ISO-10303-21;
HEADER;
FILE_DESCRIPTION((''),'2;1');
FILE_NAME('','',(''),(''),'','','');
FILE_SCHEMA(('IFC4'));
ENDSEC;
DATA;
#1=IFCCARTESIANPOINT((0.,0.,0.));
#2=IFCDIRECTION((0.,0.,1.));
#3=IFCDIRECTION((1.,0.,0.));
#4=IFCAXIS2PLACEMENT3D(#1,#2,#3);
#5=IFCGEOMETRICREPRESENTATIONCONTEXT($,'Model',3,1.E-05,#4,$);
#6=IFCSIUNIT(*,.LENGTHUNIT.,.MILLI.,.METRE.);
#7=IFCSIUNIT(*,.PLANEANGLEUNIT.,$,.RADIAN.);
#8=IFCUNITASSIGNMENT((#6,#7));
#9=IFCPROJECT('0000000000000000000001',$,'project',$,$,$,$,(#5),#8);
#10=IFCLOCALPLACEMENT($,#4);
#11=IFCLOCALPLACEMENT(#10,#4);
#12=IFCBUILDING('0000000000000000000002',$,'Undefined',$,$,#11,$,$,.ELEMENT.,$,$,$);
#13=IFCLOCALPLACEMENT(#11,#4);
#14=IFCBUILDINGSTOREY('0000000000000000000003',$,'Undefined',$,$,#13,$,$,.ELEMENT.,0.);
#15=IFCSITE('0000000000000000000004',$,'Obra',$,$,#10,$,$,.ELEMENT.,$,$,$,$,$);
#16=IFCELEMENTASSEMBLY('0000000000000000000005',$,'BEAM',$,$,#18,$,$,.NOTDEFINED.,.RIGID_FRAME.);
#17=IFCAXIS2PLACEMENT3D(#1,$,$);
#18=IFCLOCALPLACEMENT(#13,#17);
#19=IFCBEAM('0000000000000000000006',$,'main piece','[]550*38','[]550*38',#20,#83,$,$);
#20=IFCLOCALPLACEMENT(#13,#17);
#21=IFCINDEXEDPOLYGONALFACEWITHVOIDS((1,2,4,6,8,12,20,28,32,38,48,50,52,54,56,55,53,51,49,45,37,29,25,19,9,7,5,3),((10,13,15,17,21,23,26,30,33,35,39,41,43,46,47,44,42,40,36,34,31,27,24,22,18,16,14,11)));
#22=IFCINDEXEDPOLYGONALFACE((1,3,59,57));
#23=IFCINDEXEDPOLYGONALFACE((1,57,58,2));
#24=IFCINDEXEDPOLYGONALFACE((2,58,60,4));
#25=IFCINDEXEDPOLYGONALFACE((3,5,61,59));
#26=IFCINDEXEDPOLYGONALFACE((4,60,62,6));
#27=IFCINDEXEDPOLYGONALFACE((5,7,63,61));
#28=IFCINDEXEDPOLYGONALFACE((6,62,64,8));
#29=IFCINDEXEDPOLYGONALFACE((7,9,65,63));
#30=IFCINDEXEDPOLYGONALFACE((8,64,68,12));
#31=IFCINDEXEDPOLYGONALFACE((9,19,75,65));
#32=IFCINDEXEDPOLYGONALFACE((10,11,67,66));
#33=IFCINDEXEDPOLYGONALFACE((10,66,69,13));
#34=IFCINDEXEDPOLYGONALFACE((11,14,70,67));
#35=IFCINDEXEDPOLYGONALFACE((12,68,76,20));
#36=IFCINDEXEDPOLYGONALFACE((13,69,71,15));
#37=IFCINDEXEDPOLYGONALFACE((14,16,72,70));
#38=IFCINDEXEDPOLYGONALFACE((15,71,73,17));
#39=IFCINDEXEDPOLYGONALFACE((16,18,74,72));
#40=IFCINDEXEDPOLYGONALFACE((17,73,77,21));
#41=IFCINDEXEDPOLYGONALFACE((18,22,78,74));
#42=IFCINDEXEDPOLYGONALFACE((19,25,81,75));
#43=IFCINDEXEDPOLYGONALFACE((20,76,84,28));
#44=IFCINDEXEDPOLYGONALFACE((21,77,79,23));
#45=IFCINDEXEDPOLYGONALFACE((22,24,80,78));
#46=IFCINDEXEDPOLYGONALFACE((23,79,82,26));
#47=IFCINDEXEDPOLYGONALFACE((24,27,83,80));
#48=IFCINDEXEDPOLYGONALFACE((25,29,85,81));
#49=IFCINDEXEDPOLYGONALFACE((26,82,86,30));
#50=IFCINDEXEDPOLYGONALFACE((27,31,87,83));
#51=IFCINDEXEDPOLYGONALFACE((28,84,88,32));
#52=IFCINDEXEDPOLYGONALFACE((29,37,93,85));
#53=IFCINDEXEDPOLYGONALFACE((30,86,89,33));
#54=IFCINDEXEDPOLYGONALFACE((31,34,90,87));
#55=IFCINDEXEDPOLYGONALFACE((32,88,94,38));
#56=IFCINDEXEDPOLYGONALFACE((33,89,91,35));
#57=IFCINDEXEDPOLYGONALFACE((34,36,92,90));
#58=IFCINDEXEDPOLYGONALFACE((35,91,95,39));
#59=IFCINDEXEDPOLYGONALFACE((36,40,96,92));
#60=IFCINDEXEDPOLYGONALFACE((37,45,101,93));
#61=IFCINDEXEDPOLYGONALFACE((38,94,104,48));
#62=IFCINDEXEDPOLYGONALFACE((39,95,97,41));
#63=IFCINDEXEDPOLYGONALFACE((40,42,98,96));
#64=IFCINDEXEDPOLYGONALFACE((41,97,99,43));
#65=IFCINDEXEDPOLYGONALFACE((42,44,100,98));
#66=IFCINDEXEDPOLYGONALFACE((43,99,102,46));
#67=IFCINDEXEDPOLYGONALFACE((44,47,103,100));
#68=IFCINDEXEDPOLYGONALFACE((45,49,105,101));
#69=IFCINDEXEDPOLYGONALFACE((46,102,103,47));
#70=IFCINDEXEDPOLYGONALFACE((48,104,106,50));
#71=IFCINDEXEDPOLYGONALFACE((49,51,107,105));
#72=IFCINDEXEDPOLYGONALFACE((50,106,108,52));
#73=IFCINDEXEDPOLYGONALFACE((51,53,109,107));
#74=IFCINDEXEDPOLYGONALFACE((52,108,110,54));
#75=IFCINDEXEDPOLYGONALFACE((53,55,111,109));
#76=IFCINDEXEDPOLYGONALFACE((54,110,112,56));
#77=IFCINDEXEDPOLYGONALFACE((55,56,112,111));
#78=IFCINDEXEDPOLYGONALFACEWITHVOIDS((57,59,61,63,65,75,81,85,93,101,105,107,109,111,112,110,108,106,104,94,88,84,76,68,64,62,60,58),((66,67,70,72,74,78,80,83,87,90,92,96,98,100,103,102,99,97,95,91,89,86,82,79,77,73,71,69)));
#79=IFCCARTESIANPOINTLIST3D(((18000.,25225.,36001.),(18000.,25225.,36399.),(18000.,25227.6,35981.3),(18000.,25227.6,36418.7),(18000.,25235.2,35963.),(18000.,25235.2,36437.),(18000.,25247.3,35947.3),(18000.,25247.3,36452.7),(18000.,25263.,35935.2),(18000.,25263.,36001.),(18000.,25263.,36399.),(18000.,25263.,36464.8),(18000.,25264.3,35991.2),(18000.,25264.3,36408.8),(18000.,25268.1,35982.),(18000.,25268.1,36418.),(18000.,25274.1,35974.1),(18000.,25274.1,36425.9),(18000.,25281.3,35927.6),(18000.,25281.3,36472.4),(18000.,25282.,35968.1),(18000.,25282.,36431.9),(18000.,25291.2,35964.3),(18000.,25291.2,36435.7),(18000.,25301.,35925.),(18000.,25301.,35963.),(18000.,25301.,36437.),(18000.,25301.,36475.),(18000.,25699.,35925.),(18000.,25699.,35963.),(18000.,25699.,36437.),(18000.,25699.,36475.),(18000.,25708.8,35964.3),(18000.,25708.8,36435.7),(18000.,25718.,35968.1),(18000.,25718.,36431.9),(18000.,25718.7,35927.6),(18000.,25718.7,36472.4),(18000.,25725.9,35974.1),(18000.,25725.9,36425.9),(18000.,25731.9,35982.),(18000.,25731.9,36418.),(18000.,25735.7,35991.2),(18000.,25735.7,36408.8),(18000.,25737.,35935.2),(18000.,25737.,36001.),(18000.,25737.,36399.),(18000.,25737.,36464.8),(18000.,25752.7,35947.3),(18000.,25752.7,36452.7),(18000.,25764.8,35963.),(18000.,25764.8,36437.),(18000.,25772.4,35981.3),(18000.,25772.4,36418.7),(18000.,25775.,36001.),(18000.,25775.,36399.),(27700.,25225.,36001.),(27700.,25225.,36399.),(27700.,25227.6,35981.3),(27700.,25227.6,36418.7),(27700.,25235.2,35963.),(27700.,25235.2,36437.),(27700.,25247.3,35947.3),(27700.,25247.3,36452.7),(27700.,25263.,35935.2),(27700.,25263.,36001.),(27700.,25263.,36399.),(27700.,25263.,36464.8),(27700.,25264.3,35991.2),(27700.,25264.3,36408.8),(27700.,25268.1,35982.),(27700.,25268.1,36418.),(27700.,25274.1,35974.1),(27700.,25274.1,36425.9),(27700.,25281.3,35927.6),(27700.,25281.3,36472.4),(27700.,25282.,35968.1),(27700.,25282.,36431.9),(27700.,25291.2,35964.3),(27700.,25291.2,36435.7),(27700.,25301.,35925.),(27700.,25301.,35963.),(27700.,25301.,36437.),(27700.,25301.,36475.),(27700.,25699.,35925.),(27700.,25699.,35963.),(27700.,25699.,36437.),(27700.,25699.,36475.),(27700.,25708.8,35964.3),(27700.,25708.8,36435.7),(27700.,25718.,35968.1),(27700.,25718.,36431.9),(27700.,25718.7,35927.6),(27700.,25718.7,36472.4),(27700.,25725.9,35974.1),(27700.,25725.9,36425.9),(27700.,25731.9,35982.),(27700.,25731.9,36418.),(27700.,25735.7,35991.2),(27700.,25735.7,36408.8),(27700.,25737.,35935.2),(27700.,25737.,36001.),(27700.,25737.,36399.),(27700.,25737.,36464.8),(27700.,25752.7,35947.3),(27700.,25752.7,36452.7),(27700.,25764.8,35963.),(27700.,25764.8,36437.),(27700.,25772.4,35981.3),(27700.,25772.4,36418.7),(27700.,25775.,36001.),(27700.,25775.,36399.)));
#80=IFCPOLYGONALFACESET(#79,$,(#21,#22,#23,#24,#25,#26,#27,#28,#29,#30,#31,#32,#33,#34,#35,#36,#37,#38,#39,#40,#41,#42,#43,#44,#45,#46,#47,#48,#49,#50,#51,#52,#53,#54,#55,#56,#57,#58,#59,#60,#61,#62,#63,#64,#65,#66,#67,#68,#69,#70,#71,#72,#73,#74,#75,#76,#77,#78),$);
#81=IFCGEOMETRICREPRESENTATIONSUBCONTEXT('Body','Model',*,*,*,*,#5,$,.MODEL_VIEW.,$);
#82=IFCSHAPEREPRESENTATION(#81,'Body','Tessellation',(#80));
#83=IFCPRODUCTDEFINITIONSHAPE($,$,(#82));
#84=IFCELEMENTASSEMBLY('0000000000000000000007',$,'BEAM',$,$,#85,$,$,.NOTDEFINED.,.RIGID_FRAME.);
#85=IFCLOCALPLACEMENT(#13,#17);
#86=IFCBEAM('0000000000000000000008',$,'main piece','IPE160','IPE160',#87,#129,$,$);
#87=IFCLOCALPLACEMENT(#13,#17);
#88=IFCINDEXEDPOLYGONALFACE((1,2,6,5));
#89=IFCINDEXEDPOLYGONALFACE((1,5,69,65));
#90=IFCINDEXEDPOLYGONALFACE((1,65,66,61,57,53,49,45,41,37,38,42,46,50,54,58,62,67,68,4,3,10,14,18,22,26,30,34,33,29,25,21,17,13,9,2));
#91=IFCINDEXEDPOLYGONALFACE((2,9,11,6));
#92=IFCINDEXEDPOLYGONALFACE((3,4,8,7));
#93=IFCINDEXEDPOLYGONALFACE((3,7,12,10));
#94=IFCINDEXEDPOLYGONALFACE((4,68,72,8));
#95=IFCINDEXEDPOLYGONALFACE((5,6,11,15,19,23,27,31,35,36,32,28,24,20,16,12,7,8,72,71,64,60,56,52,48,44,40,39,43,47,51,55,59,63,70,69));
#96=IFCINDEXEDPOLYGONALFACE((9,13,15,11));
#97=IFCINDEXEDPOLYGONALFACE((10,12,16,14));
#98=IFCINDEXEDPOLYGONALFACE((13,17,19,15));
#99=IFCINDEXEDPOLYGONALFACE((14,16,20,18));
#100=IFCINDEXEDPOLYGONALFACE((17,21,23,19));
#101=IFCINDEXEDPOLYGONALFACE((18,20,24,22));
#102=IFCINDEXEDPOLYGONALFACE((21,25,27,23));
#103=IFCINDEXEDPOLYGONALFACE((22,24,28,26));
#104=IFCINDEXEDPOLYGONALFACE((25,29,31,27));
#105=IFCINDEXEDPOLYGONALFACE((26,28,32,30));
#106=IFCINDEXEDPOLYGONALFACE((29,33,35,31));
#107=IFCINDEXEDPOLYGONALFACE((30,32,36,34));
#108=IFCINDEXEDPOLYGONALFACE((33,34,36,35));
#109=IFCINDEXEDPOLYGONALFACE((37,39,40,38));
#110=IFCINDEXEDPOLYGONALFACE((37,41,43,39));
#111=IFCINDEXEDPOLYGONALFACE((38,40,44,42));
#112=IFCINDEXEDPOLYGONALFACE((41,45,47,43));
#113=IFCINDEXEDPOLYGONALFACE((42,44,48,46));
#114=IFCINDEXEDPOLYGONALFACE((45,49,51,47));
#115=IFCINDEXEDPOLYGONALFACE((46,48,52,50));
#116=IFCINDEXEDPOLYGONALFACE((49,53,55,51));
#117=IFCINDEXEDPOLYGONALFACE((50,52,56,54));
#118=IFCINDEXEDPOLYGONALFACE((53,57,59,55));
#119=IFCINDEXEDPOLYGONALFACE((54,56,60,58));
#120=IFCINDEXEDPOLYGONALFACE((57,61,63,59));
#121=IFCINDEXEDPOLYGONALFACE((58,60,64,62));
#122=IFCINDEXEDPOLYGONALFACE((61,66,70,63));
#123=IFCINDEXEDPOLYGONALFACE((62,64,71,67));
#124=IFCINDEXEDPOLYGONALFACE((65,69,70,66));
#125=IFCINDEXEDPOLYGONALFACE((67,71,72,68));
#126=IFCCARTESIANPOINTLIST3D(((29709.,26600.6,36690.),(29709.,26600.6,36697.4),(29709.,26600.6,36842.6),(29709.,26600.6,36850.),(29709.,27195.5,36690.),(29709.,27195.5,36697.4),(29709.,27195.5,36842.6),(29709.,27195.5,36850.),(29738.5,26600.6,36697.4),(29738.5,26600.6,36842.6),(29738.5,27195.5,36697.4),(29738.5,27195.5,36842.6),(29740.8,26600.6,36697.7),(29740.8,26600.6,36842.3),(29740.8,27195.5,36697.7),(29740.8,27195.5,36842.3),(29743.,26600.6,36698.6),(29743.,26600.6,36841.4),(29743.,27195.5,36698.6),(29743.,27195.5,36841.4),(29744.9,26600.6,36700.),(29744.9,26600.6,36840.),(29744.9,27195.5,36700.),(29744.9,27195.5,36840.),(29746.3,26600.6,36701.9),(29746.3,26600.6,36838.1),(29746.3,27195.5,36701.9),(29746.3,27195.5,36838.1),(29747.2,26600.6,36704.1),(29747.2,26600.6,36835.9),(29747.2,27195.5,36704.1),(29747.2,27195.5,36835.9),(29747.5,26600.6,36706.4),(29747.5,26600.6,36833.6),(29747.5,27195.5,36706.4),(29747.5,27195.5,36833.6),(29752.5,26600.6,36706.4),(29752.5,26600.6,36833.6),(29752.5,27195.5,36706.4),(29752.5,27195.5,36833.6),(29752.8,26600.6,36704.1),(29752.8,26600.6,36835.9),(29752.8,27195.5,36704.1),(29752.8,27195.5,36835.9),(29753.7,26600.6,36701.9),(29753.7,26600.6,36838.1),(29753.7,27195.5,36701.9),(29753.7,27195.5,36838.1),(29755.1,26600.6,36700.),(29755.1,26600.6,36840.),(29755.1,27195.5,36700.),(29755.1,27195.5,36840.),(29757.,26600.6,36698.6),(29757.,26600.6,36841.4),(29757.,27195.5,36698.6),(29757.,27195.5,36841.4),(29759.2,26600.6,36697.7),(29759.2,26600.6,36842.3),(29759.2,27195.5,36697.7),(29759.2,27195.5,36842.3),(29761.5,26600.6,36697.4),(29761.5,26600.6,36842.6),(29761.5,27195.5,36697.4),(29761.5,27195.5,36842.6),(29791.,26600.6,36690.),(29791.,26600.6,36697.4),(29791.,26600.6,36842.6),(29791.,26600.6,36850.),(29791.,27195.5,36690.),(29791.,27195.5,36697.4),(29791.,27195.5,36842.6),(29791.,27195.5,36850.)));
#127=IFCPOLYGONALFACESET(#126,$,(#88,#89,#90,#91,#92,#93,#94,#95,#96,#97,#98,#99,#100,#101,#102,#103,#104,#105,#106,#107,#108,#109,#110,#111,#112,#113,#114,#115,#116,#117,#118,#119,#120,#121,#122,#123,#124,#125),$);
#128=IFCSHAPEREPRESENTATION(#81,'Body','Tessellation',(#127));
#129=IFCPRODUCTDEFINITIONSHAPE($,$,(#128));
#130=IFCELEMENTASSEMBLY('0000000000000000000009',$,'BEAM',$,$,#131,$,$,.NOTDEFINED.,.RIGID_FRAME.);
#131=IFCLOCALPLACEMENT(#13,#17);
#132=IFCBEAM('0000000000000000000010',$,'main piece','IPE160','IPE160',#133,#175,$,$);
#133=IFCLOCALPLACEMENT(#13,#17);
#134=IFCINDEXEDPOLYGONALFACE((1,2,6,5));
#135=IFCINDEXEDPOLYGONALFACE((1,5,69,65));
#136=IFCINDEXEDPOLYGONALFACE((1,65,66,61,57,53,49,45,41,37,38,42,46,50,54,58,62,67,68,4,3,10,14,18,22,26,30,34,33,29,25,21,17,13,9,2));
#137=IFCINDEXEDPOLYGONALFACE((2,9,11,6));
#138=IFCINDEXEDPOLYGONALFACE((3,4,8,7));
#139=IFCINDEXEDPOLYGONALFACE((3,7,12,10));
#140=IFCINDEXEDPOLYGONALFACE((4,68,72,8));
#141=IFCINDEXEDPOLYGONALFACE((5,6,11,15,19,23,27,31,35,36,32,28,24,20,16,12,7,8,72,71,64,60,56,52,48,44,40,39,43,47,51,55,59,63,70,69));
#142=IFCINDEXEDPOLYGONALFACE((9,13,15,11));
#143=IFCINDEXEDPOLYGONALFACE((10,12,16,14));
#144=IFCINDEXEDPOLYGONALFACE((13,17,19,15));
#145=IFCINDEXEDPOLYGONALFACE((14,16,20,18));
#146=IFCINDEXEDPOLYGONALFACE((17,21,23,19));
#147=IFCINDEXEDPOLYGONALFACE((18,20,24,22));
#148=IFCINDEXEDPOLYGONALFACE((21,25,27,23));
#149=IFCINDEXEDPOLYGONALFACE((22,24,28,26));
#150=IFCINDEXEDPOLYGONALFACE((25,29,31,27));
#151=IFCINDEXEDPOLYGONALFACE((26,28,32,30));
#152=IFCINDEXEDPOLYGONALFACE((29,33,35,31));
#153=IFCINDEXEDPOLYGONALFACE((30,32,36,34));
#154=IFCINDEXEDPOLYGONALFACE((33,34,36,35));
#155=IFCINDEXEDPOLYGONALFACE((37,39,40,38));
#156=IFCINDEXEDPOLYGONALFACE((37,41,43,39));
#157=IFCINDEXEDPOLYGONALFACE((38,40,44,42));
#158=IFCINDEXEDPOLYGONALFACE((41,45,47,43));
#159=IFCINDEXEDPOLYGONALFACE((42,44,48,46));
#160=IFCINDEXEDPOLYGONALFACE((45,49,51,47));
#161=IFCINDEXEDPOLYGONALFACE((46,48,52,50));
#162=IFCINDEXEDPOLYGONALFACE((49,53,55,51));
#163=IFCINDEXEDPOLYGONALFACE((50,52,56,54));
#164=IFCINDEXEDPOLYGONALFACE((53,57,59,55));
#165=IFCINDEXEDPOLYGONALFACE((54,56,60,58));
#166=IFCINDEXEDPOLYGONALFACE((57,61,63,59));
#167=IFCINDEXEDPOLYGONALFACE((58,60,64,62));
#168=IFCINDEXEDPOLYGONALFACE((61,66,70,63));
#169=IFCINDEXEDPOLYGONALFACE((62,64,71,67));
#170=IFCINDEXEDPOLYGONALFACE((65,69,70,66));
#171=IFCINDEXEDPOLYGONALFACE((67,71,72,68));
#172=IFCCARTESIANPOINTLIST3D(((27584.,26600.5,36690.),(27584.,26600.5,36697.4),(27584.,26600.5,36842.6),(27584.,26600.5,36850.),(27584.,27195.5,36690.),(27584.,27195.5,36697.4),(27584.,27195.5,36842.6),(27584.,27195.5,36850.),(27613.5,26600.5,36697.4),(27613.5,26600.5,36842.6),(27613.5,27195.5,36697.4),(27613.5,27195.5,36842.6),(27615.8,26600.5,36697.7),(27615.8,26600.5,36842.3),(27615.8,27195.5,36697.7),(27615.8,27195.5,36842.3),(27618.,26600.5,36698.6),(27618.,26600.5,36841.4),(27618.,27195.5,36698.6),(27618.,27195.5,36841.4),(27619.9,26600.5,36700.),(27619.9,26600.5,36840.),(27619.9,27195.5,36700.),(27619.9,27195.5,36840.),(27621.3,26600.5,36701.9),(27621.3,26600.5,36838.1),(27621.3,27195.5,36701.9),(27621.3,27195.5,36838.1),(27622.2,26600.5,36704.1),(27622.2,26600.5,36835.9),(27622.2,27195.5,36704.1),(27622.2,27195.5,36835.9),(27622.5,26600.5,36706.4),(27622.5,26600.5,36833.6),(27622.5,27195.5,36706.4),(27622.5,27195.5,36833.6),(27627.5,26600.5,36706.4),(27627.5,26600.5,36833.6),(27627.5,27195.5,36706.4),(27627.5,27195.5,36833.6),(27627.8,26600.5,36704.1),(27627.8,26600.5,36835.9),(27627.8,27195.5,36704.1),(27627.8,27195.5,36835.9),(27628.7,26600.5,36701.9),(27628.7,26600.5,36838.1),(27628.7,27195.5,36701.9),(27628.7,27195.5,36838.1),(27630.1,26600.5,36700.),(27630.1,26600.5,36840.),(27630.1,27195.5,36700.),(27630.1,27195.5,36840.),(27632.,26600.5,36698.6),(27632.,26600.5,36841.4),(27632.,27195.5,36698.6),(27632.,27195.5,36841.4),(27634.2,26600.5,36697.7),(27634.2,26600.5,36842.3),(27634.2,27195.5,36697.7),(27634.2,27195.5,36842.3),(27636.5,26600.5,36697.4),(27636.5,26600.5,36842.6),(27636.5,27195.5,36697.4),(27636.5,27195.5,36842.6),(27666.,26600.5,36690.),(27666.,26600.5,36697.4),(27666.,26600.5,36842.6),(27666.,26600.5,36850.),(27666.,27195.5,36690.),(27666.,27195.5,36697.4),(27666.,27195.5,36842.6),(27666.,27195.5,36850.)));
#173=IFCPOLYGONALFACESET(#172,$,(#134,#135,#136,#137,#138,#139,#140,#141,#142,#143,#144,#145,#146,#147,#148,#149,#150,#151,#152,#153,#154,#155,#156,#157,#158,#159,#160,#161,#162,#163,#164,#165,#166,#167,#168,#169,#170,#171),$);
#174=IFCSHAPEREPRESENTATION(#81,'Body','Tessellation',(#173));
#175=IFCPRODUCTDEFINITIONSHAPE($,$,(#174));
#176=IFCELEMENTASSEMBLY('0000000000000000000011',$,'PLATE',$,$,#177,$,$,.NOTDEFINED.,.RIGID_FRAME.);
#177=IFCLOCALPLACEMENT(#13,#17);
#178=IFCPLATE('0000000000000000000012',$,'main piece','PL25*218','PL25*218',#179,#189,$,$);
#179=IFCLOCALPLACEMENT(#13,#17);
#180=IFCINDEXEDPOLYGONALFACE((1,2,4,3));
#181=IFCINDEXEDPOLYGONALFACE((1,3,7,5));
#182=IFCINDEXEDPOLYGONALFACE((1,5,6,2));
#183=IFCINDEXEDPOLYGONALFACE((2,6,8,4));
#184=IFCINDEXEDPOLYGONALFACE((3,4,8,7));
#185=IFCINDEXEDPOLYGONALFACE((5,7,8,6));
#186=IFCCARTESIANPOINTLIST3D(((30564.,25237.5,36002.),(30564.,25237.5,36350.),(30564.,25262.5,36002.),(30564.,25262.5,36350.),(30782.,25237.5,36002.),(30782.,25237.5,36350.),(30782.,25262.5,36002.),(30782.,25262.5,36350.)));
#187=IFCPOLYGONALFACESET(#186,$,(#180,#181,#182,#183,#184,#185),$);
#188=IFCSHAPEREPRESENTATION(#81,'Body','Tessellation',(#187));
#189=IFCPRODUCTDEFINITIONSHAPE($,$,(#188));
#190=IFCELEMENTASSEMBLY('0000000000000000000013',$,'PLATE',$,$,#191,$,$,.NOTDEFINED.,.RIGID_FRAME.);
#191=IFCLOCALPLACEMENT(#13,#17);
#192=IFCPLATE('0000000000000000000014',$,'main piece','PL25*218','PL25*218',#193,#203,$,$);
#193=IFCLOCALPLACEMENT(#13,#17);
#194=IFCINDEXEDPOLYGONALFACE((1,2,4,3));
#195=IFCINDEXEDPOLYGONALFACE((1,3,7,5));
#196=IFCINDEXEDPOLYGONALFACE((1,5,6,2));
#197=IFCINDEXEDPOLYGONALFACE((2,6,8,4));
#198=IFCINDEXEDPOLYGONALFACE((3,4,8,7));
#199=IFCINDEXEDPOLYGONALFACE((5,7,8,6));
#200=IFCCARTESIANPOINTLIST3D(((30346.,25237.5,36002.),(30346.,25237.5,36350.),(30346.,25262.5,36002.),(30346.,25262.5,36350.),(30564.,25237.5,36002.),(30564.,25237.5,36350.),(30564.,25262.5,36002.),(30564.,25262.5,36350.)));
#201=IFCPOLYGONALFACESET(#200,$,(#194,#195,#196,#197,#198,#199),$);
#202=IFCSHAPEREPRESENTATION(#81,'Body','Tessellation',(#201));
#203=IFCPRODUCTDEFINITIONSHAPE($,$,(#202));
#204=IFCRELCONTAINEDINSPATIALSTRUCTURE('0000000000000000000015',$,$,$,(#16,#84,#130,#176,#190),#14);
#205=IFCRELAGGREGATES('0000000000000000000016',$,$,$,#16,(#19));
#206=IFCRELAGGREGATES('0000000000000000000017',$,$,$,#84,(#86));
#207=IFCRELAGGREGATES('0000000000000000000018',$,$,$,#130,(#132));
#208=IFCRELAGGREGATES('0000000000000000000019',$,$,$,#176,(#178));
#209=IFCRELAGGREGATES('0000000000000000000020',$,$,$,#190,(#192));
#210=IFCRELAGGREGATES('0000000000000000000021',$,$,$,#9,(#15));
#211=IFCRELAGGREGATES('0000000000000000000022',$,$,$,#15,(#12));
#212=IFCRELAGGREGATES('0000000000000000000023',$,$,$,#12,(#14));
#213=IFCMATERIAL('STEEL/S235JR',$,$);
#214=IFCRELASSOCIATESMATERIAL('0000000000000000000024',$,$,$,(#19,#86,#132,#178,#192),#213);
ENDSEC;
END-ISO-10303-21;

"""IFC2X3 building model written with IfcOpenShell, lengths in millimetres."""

from ifc_helpers import new_model, si_unit, frame, origin_with_axes, origin_2d_with_axis, place, context, subcontext, project, spatial, polyline, hollow_rectangle, i_section, outline, extrude, material, element, aggregate, save


model = new_model("IFC2X3")

# Units and contexts
model_context = context("Model", 3, precision=1e-05, world=origin_with_axes())
body_context = subcontext(model_context, "Body", "Model", "MODEL_VIEW")
ifc_project = project(units=[si_unit("LENGTHUNIT", "METRE", prefix="MILLI"), si_unit("PLANEANGLEUNIT", "RADIAN")], contexts=[model_context])

# Site, building, storey
site_placement = place(None, origin_with_axes())
site = spatial("IfcSite", under=ifc_project, at=site_placement, Name="Obra", CompositionType="ELEMENT")
building_placement = place(site_placement, origin_with_axes())
building = spatial("IfcBuilding", under=site, at=building_placement, Name="Undefined", CompositionType="ELEMENT")
storey_placement = place(building_placement, origin_with_axes())
storey = spatial("IfcBuildingStorey", under=building, at=storey_placement, Name="Undefined", CompositionType="ELEMENT", Elevation=0.0)

# Element assemblies, beams
assembly_1_placement = place(storey_placement, origin_with_axes())
assembly_1 = element("IfcElementAssembly", 1, at=assembly_1_placement, inside=storey, Name="BEAM", AssemblyPlace="NOTDEFINED", PredefinedType="RIGID_FRAME")
ifc_material_1 = material(Name="STEEL/S235JR")
beam_1_placement = place(assembly_1_placement, frame((27700.0, 25500.0, 36200.0), z_axis=(0.0, 0.0, 1.0), x_axis=(-1.0, 0.0, 0.0)))
beam_1 = element("IfcBeam", 2, at=beam_1_placement, material=ifc_material_1, Name="main piece", Description="[]550*38", ObjectType="[]550*38", context=body_context, shape_type="SweptSolid", body=[
    extrude(hollow_rectangle(XDim=550.0, YDim=550.0, WallThickness=38.0, InnerFilletRadius=38.0, OuterFilletRadius=76.0, at=origin_2d_with_axis()), frame((9700.0, 0.0, 0.0), z_axis=(-1.0, 0.0, 0.0), x_axis=(0.0, -1.0, 0.0)), (0.0, 0.0, 1.0), 9700.0),
])
aggregate(assembly_1, [beam_1])
assembly_2_placement = place(storey_placement, origin_with_axes())
assembly_2 = element("IfcElementAssembly", 3, at=assembly_2_placement, inside=storey, Name="BEAM", AssemblyPlace="NOTDEFINED", PredefinedType="RIGID_FRAME")
beam_2_placement = place(assembly_2_placement, frame((29750.0, 26600.6, 36770.0), z_axis=(0.0, 0.0, 1.0), x_axis=(0.0, 1.0, 0.0)))
beam_2 = element("IfcBeam", 4, at=beam_2_placement, material=ifc_material_1, Name="main piece", Description="IPE160", ObjectType="IPE160", context=body_context, shape_type="SweptSolid", body=[
    extrude(i_section(OverallWidth=82.0, OverallDepth=160.0, WebThickness=5.0, FlangeThickness=7.4, FilletRadius=9.0, at=origin_2d_with_axis()), frame((594.9, 0.0, 0.0), z_axis=(-1.0, 0.0, 0.0), x_axis=(0.0, -1.0, 0.0)), (0.0, 0.0, 1.0), 594.9),
])
aggregate(assembly_2, [beam_2])
assembly_3_placement = place(storey_placement, origin_with_axes())
assembly_3 = element("IfcElementAssembly", 5, at=assembly_3_placement, inside=storey, Name="BEAM", AssemblyPlace="NOTDEFINED", PredefinedType="RIGID_FRAME")
beam_3_placement = place(assembly_3_placement, frame((27625.0, 26600.5, 36770.0), z_axis=(0.0, 0.0, 1.0), x_axis=(0.0, 1.0, 0.0)))
beam_3 = element("IfcBeam", 6, at=beam_3_placement, material=ifc_material_1, Name="main piece", Description="IPE160", ObjectType="IPE160", context=body_context, shape_type="SweptSolid", body=[
    extrude(i_section(OverallWidth=82.0, OverallDepth=160.0, WebThickness=5.0, FlangeThickness=7.4, FilletRadius=9.0, at=origin_2d_with_axis()), frame((595.0, 0.0, 0.0), z_axis=(-1.0, 0.0, 0.0), x_axis=(0.0, -1.0, 0.0)), (0.0, 0.0, 1.0), 595.0),
])
aggregate(assembly_3, [beam_3])

# Element assemblies, plates
assembly_4_placement = place(storey_placement, origin_with_axes())
assembly_4 = element("IfcElementAssembly", 7, at=assembly_4_placement, inside=storey, Name="PLATE", AssemblyPlace="NOTDEFINED", PredefinedType="RIGID_FRAME")
plate_1_placement = place(assembly_4_placement, frame((30564.0, 25250.0, 36002.0), z_axis=(0.0, -1.0, 0.0), x_axis=(1.0, 0.0, 0.0)))
plate_1 = element("IfcPlate", 8, at=plate_1_placement, material=ifc_material_1, Name="main piece", Description="PL25*218", ObjectType="PL25*218", context=body_context, shape_type="SweptSolid", body=[
    extrude(outline(polyline([(0.0, 0.0), (218.0, 0.0), (218.0, 348.0), (0.0, 348.0), (0.0, 0.0)])), frame((0.0, 0.0, -12.5), z_axis=(0.0, 0.0, 1.0), x_axis=(1.0, 0.0, 0.0)), (0.0, 0.0, 1.0), 25.0),
])
aggregate(assembly_4, [plate_1])
assembly_5_placement = place(storey_placement, origin_with_axes())
assembly_5 = element("IfcElementAssembly", 9, at=assembly_5_placement, inside=storey, Name="PLATE", AssemblyPlace="NOTDEFINED", PredefinedType="RIGID_FRAME")
plate_2_placement = place(assembly_5_placement, frame((30346.0, 25250.0, 36002.0), z_axis=(0.0, -1.0, 0.0), x_axis=(1.0, 0.0, 0.0)))
plate_2 = element("IfcPlate", 10, at=plate_2_placement, material=ifc_material_1, Name="main piece", Description="PL25*218", ObjectType="PL25*218", context=body_context, shape_type="SweptSolid", body=[
    extrude(outline(polyline([(0.0, 0.0), (218.0, 0.0), (218.0, 348.0), (0.0, 348.0), (0.0, 0.0)])), frame((0.0, 0.0, -12.5), z_axis=(0.0, 0.0, 1.0), x_axis=(1.0, 0.0, 0.0)), (0.0, 0.0, 1.0), 25.0),
])
aggregate(assembly_5, [plate_2])

save(model, "model.ifc")
